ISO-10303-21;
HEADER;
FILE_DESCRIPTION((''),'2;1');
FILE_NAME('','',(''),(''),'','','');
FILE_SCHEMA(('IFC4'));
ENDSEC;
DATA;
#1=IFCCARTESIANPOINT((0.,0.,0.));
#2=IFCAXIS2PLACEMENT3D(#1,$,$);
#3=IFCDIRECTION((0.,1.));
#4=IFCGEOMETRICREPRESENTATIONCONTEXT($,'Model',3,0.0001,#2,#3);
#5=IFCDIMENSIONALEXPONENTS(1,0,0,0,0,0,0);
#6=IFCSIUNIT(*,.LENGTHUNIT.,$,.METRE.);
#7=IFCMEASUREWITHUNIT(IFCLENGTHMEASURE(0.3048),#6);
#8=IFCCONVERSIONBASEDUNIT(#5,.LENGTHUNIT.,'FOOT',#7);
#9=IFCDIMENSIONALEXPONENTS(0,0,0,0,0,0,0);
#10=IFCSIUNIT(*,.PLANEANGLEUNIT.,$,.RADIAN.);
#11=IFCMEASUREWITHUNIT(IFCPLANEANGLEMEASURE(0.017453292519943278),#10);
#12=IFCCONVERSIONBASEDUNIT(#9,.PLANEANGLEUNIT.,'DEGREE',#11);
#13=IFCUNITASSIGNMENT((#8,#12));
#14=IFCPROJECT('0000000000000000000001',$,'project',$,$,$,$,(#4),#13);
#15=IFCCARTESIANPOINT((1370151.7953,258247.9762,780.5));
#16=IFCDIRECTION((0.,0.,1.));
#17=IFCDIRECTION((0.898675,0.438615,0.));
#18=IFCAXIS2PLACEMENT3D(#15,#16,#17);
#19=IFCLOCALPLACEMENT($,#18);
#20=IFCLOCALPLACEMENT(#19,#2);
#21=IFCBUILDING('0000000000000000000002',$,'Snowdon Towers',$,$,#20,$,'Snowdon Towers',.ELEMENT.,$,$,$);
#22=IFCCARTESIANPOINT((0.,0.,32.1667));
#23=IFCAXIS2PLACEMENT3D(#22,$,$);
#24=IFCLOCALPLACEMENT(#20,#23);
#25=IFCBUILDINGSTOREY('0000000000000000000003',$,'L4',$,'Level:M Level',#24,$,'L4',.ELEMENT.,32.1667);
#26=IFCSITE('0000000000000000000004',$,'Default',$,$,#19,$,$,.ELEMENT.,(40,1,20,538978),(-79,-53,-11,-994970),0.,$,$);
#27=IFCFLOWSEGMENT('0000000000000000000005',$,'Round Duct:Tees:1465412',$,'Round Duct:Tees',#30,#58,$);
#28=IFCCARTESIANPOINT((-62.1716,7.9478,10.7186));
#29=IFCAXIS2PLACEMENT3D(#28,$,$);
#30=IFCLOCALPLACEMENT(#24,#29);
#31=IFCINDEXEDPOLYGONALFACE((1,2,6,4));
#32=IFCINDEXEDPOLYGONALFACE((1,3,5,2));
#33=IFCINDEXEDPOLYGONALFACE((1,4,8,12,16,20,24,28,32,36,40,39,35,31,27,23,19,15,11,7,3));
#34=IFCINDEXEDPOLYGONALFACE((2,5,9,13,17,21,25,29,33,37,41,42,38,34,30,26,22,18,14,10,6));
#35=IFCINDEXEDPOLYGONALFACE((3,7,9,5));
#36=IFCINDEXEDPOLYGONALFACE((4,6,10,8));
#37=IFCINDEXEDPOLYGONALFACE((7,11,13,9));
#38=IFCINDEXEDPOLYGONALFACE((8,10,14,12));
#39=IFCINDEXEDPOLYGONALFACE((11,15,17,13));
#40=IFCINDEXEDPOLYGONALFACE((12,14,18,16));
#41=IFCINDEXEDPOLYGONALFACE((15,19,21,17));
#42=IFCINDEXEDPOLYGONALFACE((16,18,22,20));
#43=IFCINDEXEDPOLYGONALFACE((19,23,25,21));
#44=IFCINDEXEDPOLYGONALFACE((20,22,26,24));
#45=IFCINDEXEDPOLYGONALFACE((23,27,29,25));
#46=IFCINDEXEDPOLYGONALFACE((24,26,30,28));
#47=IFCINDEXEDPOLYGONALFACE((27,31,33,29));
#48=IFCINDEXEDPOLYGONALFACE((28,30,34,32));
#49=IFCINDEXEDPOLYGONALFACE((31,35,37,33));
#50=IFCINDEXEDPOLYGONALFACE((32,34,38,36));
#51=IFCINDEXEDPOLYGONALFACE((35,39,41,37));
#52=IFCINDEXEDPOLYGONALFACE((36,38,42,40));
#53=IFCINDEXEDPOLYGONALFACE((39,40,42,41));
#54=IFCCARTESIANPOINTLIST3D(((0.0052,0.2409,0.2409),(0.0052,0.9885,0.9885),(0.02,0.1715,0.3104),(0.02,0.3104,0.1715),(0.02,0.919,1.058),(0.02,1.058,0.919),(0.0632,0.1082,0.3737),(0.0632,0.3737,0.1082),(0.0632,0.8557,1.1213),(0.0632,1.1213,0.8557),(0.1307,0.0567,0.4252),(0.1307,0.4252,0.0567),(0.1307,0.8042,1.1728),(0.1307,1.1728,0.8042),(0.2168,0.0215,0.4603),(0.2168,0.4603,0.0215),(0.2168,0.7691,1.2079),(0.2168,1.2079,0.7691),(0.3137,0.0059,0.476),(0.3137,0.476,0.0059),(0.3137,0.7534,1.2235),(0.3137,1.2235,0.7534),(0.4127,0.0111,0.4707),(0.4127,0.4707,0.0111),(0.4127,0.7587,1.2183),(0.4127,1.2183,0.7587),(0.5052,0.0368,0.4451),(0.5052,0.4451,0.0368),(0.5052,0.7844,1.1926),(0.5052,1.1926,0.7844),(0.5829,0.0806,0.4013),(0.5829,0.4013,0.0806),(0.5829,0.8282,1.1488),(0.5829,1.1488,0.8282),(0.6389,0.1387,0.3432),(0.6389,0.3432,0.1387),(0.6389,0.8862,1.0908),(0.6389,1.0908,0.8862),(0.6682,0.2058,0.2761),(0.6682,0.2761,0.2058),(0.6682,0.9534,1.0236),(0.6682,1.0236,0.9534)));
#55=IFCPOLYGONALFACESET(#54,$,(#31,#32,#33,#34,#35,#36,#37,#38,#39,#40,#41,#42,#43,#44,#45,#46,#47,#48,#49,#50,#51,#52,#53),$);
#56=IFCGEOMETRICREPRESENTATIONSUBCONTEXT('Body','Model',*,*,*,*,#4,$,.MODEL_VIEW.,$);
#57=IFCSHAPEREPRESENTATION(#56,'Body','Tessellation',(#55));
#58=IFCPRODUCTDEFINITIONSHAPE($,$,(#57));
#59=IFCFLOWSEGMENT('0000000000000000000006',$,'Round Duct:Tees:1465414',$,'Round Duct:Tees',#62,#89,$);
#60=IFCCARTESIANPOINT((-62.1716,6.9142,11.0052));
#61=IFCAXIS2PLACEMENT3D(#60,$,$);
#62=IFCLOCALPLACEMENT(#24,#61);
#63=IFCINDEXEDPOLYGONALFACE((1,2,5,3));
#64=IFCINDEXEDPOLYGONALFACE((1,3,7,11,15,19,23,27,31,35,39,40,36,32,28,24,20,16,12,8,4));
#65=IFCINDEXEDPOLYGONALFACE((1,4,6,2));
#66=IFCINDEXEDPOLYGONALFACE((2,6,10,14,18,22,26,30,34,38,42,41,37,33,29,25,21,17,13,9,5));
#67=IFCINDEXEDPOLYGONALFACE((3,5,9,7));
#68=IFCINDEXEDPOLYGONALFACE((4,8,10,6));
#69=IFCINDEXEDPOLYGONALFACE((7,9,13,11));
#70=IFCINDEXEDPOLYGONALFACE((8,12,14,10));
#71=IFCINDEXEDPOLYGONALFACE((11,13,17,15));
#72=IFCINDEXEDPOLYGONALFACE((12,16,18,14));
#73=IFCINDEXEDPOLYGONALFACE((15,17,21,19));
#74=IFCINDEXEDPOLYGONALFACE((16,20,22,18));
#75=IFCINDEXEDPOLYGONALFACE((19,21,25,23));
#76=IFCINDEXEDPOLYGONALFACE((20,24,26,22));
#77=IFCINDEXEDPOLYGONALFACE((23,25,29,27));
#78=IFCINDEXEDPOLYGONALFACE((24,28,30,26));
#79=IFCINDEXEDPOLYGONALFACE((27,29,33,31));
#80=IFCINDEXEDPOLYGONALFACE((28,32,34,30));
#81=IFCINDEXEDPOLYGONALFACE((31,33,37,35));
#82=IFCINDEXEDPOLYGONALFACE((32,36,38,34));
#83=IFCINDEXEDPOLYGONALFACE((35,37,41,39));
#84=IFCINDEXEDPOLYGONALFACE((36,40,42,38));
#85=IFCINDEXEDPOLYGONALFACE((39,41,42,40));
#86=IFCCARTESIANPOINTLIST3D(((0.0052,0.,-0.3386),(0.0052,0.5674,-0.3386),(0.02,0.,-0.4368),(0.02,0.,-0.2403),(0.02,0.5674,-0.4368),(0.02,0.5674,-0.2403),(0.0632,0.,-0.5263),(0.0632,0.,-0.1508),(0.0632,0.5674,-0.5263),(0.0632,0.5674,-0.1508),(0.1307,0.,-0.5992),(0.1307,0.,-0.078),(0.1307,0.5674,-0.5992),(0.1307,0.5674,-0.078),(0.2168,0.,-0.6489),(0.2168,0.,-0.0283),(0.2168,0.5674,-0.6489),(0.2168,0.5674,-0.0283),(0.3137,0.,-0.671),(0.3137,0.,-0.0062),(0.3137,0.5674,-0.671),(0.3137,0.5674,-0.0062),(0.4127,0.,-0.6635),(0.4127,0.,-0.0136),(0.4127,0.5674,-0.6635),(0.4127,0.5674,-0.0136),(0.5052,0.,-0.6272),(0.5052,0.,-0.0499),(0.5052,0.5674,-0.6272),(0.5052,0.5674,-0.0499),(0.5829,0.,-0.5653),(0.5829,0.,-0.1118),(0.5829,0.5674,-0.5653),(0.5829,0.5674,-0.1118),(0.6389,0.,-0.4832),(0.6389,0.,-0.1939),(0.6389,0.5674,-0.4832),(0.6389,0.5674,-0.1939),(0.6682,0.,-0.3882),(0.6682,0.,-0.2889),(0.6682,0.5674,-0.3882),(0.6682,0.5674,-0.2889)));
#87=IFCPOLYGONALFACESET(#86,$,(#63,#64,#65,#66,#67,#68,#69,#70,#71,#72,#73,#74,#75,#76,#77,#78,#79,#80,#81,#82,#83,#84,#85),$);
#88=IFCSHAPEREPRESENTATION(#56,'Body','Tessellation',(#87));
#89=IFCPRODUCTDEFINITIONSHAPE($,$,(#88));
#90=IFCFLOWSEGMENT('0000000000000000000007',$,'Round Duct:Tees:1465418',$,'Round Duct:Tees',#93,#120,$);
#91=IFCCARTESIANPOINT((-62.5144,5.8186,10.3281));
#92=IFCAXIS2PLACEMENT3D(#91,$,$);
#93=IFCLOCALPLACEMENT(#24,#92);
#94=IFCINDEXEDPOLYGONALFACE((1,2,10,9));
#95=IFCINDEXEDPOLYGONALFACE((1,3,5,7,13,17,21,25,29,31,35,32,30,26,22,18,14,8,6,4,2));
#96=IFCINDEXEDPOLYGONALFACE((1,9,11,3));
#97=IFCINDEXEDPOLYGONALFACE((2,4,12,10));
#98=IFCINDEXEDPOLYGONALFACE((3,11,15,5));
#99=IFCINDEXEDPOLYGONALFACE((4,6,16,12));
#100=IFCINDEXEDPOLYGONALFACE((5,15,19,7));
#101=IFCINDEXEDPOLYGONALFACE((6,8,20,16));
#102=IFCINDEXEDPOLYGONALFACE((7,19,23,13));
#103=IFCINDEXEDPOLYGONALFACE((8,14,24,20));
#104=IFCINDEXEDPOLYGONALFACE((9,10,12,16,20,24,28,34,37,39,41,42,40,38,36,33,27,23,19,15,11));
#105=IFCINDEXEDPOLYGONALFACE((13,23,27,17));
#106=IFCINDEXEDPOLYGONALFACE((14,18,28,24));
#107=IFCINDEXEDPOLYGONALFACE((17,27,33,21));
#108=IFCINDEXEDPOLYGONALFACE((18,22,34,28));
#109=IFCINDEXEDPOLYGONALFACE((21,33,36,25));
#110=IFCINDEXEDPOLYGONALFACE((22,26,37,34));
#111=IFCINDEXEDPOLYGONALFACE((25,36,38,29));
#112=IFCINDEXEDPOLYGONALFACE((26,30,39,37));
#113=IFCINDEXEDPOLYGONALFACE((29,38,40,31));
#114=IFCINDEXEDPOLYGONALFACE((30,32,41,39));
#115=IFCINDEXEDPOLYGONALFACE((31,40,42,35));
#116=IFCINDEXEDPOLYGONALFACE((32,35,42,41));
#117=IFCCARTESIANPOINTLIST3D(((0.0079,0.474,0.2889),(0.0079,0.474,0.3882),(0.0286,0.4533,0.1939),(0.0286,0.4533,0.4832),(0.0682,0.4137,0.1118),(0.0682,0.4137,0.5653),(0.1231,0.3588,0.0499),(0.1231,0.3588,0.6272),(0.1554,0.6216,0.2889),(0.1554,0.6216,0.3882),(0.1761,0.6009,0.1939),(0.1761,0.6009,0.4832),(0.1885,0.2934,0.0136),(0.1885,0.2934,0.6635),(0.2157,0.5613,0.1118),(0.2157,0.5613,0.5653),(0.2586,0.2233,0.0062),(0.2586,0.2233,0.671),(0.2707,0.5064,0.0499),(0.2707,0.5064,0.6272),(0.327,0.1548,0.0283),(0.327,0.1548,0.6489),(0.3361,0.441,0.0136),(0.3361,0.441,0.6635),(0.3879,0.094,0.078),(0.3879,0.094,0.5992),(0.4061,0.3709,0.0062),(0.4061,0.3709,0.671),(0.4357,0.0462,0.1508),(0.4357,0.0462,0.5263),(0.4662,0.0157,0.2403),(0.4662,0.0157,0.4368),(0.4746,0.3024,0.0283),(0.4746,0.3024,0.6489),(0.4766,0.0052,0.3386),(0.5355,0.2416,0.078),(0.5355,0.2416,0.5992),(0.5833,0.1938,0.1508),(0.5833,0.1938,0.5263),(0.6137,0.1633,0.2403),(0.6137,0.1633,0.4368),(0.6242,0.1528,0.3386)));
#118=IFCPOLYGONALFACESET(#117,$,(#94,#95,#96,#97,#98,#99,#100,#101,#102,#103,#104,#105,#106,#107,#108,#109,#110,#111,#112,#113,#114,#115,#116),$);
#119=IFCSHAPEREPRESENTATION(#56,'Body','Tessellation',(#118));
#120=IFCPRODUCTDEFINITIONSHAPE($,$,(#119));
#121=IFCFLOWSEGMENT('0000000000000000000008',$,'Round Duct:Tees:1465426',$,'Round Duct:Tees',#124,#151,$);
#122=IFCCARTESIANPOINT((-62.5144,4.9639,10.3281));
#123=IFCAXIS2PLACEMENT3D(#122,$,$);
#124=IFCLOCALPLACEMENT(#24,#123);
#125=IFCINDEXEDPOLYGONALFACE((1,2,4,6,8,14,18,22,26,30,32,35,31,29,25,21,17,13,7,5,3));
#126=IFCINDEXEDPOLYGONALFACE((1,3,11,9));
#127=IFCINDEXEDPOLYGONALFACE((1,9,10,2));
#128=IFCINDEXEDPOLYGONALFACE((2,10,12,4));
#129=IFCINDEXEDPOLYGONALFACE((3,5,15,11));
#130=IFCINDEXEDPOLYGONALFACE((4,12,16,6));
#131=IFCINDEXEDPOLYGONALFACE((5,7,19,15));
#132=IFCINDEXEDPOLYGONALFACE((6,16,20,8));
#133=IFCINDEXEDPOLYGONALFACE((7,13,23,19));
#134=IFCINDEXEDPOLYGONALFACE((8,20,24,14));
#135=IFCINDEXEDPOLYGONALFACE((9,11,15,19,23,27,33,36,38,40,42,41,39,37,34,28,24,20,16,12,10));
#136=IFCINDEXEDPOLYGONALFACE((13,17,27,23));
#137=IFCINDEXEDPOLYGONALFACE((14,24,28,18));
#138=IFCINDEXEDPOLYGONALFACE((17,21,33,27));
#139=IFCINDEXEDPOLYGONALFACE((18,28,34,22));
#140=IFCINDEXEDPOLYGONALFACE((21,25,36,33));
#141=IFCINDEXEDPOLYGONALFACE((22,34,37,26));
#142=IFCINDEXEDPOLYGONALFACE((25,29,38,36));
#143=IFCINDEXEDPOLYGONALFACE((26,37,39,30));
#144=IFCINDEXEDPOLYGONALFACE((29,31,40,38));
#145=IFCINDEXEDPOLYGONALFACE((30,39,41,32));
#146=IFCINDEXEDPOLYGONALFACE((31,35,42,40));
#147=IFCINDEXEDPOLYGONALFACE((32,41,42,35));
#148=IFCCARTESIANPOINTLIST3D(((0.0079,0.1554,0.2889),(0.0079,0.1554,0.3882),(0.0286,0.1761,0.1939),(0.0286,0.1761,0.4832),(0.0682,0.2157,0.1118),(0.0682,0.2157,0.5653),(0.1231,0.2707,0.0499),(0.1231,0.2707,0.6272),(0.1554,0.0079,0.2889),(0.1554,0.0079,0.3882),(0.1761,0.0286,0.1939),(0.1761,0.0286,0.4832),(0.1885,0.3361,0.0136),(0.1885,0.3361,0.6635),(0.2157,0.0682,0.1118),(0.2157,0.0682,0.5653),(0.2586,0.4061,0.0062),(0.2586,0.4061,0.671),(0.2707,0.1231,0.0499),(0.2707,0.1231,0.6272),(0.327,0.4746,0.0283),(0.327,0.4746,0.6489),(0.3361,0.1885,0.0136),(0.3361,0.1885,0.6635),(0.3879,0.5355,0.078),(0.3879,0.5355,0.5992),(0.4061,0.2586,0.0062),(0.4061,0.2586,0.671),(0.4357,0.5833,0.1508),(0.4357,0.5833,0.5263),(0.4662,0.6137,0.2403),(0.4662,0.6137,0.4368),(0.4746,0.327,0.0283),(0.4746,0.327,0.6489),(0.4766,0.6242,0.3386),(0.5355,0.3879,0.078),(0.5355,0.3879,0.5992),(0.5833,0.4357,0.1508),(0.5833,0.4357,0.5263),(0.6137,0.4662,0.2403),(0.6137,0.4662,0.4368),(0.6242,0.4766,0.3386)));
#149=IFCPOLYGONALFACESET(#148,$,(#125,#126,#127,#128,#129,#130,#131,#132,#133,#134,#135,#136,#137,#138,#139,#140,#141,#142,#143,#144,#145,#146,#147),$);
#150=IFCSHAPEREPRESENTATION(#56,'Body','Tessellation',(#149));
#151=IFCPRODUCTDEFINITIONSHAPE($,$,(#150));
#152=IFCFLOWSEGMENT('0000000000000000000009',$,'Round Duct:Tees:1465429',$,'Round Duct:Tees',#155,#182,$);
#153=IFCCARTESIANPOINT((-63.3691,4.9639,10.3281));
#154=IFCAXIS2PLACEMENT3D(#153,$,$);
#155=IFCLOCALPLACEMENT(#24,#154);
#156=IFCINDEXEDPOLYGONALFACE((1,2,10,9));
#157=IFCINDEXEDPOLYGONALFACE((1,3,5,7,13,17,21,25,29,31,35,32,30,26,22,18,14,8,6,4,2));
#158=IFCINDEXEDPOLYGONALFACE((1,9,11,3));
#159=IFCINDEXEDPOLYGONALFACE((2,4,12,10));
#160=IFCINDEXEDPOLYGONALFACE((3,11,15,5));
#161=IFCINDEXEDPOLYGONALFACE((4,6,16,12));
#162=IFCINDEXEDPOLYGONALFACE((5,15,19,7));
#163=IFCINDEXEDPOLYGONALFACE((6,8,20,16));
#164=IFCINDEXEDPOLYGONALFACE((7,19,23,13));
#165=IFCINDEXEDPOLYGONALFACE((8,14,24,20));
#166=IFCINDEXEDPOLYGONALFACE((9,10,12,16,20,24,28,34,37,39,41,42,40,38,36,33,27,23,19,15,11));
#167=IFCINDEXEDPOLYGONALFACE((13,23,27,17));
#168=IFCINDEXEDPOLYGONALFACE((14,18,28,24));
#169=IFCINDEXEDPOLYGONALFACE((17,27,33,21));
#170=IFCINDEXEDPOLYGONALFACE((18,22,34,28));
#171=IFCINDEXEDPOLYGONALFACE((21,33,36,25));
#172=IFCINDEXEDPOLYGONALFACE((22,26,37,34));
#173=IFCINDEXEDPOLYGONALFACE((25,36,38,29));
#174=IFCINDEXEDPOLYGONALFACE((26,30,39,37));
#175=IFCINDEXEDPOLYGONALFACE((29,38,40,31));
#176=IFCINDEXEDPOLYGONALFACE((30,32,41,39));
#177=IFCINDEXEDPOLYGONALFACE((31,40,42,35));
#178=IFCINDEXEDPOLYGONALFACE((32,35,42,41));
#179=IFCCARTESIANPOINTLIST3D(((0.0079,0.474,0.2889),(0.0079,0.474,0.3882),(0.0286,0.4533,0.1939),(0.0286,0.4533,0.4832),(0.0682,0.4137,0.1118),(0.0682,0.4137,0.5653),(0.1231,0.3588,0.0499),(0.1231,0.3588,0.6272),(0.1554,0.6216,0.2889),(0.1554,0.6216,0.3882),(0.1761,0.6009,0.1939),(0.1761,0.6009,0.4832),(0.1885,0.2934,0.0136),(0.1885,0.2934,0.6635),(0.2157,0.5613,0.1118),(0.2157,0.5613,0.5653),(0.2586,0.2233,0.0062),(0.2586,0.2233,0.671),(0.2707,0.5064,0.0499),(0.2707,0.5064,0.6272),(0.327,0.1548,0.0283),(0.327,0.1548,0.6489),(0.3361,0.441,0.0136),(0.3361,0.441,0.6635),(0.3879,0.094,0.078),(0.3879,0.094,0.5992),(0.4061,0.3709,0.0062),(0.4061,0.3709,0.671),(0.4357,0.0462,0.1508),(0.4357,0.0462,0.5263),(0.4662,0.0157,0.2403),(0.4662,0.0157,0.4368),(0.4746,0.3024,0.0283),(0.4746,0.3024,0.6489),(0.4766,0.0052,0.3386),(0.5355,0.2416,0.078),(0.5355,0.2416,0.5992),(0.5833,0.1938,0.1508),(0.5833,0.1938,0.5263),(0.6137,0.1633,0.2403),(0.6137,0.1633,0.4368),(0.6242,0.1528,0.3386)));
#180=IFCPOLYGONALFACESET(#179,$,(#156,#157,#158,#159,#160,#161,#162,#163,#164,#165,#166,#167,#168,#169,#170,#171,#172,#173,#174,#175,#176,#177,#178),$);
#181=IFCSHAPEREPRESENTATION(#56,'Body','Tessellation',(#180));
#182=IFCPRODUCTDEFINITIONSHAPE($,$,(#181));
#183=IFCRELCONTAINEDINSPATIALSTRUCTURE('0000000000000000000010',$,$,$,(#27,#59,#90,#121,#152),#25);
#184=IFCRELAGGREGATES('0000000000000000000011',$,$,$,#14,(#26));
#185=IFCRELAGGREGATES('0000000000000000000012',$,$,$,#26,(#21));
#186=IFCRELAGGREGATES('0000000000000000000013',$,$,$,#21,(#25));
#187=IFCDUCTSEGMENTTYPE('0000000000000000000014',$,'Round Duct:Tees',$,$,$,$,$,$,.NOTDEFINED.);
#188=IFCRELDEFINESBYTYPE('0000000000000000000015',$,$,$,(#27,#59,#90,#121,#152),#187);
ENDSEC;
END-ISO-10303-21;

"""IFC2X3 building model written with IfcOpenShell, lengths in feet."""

from ifc_helpers import new_model, entity, si_unit, converted_unit, direction, frame, frame_2d, origin, origin_2d_with_axis, place, context, subcontext, project, spatial, circle, extrude, type_object, element, save


model = new_model("IFC2X3")

# Units and contexts
model_context = context("Model", 3, precision=0.0001, world=origin(), true_north=direction((0.0, 1.0)))
body_context = subcontext(model_context, "Body", "Model", "MODEL_VIEW")
ifc_project = project(units=[converted_unit("LENGTHUNIT", "FOOT", entity("IfcLengthMeasure", 0.3048), si_unit("LENGTHUNIT", "METRE"), dimensions=[1, 0, 0, 0, 0, 0, 0]), converted_unit("PLANEANGLEUNIT", "DEGREE", entity("IfcPlaneAngleMeasure", 0.017453292519943278), si_unit("PLANEANGLEUNIT", "RADIAN"), dimensions=[0, 0, 0, 0, 0, 0, 0])], contexts=[model_context])

# Site, building, storey
site_placement = place(None, frame((1370151.7953, 258247.9762, 780.5), z_axis=(0.0, 0.0, 1.0), x_axis=(0.898675, 0.438615, 0.0)))
site = spatial("IfcSite", under=ifc_project, at=site_placement, Name="Default", CompositionType="ELEMENT", RefLatitude=(40, 1, 20, 538978), RefLongitude=(-79, -53, -11, -994970), RefElevation=0.0)
building_placement = place(site_placement, origin())
building = spatial("IfcBuilding", under=site, at=building_placement, Name="Snowdon Towers", LongName="Snowdon Towers", CompositionType="ELEMENT")
storey_placement = place(building_placement, frame((0.0, 0.0, 32.1667)))
storey = spatial("IfcBuildingStorey", under=building, at=storey_placement, Name="L4", ObjectType="Level:M Level", LongName="L4", CompositionType="ELEMENT", Elevation=32.1667)

# Flow segments
duct_segment_type = type_object("IfcDuctSegmentType", Name="Round Duct:Tees", PredefinedType="NOTDEFINED")
flow_segment_1_placement = place(storey_placement, frame((-62.1716, 7.9478, 10.7186)))
element("IfcFlowSegment", 1, at=flow_segment_1_placement, inside=storey, type_object=duct_segment_type, Name="Round Duct:Tees:1465412", ObjectType="Round Duct:Tees", context=body_context, shape_type="SweptSolid", body=[
    extrude(circle(Radius=0.3333, at=frame_2d((0.0, 0.0), x_axis=(1.0, 0.0))), frame((0.3386, 0.2409, 0.2409), z_axis=(0.0, 0.707107, 0.707107), x_axis=(-1.0, 0.0, 0.0)), (0.0, 0.0, 1.0), 1.0572),
])
flow_segment_2_placement = place(storey_placement, frame((-62.1716, 6.9142, 11.0052)))
element("IfcFlowSegment", 2, at=flow_segment_2_placement, inside=storey, type_object=duct_segment_type, Name="Round Duct:Tees:1465414", ObjectType="Round Duct:Tees", context=body_context, shape_type="SweptSolid", body=[
    extrude(circle(Radius=0.3333, at=frame_2d((0.0, 0.0), x_axis=(1.0, 0.0))), frame((0.3386, 0.0, -0.3386), z_axis=(0.0, 1.0, 0.0), x_axis=(-1.0, 0.0, 0.0)), (0.0, 0.0, 1.0), 0.5674),
])
flow_segment_3_placement = place(storey_placement, frame((-62.5144, 5.8186, 10.3281)))
element("IfcFlowSegment", 3, at=flow_segment_3_placement, inside=storey, type_object=duct_segment_type, Name="Round Duct:Tees:1465418", ObjectType="Round Duct:Tees", context=body_context, shape_type="SweptSolid", body=[
    extrude(circle(Radius=0.3333, at=frame_2d((0.0, 0.0), x_axis=(1.0, 0.0))), frame((0.2409, 0.2409, 0.3386), z_axis=(0.707107, 0.707107, 0.0), x_axis=(0.707107, -0.707107, 0.0)), (0.0, 0.0, 1.0), 0.2087),
])
flow_segment_4_placement = place(storey_placement, frame((-62.5144, 4.9639, 10.3281)))
element("IfcFlowSegment", 4, at=flow_segment_4_placement, inside=storey, type_object=duct_segment_type, Name="Round Duct:Tees:1465426", ObjectType="Round Duct:Tees", context=body_context, shape_type="SweptSolid", body=[
    extrude(circle(Radius=0.3333, at=origin_2d_with_axis()), frame((0.2409, 0.3885, 0.3386), z_axis=(0.707107, -0.707107, 0.0), x_axis=(0.707107, 0.707107, 0.0)), (0.0, 0.0, 1.0), 0.2087),
])
flow_segment_5_placement = place(storey_placement, frame((-63.3691, 4.9639, 10.3281)))
element("IfcFlowSegment", 5, at=flow_segment_5_placement, inside=storey, type_object=duct_segment_type, Name="Round Duct:Tees:1465429", ObjectType="Round Duct:Tees", context=body_context, shape_type="SweptSolid", body=[
    extrude(circle(Radius=0.3333, at=frame_2d((0.0, 0.0), x_axis=(1.0, 0.0))), frame((0.2409, 0.2409, 0.3386), z_axis=(0.707107, 0.707107, 0.0), x_axis=(0.707107, -0.707107, 0.0)), (0.0, 0.0, 1.0), 0.2087),
])

save(model, "model.ifc")
